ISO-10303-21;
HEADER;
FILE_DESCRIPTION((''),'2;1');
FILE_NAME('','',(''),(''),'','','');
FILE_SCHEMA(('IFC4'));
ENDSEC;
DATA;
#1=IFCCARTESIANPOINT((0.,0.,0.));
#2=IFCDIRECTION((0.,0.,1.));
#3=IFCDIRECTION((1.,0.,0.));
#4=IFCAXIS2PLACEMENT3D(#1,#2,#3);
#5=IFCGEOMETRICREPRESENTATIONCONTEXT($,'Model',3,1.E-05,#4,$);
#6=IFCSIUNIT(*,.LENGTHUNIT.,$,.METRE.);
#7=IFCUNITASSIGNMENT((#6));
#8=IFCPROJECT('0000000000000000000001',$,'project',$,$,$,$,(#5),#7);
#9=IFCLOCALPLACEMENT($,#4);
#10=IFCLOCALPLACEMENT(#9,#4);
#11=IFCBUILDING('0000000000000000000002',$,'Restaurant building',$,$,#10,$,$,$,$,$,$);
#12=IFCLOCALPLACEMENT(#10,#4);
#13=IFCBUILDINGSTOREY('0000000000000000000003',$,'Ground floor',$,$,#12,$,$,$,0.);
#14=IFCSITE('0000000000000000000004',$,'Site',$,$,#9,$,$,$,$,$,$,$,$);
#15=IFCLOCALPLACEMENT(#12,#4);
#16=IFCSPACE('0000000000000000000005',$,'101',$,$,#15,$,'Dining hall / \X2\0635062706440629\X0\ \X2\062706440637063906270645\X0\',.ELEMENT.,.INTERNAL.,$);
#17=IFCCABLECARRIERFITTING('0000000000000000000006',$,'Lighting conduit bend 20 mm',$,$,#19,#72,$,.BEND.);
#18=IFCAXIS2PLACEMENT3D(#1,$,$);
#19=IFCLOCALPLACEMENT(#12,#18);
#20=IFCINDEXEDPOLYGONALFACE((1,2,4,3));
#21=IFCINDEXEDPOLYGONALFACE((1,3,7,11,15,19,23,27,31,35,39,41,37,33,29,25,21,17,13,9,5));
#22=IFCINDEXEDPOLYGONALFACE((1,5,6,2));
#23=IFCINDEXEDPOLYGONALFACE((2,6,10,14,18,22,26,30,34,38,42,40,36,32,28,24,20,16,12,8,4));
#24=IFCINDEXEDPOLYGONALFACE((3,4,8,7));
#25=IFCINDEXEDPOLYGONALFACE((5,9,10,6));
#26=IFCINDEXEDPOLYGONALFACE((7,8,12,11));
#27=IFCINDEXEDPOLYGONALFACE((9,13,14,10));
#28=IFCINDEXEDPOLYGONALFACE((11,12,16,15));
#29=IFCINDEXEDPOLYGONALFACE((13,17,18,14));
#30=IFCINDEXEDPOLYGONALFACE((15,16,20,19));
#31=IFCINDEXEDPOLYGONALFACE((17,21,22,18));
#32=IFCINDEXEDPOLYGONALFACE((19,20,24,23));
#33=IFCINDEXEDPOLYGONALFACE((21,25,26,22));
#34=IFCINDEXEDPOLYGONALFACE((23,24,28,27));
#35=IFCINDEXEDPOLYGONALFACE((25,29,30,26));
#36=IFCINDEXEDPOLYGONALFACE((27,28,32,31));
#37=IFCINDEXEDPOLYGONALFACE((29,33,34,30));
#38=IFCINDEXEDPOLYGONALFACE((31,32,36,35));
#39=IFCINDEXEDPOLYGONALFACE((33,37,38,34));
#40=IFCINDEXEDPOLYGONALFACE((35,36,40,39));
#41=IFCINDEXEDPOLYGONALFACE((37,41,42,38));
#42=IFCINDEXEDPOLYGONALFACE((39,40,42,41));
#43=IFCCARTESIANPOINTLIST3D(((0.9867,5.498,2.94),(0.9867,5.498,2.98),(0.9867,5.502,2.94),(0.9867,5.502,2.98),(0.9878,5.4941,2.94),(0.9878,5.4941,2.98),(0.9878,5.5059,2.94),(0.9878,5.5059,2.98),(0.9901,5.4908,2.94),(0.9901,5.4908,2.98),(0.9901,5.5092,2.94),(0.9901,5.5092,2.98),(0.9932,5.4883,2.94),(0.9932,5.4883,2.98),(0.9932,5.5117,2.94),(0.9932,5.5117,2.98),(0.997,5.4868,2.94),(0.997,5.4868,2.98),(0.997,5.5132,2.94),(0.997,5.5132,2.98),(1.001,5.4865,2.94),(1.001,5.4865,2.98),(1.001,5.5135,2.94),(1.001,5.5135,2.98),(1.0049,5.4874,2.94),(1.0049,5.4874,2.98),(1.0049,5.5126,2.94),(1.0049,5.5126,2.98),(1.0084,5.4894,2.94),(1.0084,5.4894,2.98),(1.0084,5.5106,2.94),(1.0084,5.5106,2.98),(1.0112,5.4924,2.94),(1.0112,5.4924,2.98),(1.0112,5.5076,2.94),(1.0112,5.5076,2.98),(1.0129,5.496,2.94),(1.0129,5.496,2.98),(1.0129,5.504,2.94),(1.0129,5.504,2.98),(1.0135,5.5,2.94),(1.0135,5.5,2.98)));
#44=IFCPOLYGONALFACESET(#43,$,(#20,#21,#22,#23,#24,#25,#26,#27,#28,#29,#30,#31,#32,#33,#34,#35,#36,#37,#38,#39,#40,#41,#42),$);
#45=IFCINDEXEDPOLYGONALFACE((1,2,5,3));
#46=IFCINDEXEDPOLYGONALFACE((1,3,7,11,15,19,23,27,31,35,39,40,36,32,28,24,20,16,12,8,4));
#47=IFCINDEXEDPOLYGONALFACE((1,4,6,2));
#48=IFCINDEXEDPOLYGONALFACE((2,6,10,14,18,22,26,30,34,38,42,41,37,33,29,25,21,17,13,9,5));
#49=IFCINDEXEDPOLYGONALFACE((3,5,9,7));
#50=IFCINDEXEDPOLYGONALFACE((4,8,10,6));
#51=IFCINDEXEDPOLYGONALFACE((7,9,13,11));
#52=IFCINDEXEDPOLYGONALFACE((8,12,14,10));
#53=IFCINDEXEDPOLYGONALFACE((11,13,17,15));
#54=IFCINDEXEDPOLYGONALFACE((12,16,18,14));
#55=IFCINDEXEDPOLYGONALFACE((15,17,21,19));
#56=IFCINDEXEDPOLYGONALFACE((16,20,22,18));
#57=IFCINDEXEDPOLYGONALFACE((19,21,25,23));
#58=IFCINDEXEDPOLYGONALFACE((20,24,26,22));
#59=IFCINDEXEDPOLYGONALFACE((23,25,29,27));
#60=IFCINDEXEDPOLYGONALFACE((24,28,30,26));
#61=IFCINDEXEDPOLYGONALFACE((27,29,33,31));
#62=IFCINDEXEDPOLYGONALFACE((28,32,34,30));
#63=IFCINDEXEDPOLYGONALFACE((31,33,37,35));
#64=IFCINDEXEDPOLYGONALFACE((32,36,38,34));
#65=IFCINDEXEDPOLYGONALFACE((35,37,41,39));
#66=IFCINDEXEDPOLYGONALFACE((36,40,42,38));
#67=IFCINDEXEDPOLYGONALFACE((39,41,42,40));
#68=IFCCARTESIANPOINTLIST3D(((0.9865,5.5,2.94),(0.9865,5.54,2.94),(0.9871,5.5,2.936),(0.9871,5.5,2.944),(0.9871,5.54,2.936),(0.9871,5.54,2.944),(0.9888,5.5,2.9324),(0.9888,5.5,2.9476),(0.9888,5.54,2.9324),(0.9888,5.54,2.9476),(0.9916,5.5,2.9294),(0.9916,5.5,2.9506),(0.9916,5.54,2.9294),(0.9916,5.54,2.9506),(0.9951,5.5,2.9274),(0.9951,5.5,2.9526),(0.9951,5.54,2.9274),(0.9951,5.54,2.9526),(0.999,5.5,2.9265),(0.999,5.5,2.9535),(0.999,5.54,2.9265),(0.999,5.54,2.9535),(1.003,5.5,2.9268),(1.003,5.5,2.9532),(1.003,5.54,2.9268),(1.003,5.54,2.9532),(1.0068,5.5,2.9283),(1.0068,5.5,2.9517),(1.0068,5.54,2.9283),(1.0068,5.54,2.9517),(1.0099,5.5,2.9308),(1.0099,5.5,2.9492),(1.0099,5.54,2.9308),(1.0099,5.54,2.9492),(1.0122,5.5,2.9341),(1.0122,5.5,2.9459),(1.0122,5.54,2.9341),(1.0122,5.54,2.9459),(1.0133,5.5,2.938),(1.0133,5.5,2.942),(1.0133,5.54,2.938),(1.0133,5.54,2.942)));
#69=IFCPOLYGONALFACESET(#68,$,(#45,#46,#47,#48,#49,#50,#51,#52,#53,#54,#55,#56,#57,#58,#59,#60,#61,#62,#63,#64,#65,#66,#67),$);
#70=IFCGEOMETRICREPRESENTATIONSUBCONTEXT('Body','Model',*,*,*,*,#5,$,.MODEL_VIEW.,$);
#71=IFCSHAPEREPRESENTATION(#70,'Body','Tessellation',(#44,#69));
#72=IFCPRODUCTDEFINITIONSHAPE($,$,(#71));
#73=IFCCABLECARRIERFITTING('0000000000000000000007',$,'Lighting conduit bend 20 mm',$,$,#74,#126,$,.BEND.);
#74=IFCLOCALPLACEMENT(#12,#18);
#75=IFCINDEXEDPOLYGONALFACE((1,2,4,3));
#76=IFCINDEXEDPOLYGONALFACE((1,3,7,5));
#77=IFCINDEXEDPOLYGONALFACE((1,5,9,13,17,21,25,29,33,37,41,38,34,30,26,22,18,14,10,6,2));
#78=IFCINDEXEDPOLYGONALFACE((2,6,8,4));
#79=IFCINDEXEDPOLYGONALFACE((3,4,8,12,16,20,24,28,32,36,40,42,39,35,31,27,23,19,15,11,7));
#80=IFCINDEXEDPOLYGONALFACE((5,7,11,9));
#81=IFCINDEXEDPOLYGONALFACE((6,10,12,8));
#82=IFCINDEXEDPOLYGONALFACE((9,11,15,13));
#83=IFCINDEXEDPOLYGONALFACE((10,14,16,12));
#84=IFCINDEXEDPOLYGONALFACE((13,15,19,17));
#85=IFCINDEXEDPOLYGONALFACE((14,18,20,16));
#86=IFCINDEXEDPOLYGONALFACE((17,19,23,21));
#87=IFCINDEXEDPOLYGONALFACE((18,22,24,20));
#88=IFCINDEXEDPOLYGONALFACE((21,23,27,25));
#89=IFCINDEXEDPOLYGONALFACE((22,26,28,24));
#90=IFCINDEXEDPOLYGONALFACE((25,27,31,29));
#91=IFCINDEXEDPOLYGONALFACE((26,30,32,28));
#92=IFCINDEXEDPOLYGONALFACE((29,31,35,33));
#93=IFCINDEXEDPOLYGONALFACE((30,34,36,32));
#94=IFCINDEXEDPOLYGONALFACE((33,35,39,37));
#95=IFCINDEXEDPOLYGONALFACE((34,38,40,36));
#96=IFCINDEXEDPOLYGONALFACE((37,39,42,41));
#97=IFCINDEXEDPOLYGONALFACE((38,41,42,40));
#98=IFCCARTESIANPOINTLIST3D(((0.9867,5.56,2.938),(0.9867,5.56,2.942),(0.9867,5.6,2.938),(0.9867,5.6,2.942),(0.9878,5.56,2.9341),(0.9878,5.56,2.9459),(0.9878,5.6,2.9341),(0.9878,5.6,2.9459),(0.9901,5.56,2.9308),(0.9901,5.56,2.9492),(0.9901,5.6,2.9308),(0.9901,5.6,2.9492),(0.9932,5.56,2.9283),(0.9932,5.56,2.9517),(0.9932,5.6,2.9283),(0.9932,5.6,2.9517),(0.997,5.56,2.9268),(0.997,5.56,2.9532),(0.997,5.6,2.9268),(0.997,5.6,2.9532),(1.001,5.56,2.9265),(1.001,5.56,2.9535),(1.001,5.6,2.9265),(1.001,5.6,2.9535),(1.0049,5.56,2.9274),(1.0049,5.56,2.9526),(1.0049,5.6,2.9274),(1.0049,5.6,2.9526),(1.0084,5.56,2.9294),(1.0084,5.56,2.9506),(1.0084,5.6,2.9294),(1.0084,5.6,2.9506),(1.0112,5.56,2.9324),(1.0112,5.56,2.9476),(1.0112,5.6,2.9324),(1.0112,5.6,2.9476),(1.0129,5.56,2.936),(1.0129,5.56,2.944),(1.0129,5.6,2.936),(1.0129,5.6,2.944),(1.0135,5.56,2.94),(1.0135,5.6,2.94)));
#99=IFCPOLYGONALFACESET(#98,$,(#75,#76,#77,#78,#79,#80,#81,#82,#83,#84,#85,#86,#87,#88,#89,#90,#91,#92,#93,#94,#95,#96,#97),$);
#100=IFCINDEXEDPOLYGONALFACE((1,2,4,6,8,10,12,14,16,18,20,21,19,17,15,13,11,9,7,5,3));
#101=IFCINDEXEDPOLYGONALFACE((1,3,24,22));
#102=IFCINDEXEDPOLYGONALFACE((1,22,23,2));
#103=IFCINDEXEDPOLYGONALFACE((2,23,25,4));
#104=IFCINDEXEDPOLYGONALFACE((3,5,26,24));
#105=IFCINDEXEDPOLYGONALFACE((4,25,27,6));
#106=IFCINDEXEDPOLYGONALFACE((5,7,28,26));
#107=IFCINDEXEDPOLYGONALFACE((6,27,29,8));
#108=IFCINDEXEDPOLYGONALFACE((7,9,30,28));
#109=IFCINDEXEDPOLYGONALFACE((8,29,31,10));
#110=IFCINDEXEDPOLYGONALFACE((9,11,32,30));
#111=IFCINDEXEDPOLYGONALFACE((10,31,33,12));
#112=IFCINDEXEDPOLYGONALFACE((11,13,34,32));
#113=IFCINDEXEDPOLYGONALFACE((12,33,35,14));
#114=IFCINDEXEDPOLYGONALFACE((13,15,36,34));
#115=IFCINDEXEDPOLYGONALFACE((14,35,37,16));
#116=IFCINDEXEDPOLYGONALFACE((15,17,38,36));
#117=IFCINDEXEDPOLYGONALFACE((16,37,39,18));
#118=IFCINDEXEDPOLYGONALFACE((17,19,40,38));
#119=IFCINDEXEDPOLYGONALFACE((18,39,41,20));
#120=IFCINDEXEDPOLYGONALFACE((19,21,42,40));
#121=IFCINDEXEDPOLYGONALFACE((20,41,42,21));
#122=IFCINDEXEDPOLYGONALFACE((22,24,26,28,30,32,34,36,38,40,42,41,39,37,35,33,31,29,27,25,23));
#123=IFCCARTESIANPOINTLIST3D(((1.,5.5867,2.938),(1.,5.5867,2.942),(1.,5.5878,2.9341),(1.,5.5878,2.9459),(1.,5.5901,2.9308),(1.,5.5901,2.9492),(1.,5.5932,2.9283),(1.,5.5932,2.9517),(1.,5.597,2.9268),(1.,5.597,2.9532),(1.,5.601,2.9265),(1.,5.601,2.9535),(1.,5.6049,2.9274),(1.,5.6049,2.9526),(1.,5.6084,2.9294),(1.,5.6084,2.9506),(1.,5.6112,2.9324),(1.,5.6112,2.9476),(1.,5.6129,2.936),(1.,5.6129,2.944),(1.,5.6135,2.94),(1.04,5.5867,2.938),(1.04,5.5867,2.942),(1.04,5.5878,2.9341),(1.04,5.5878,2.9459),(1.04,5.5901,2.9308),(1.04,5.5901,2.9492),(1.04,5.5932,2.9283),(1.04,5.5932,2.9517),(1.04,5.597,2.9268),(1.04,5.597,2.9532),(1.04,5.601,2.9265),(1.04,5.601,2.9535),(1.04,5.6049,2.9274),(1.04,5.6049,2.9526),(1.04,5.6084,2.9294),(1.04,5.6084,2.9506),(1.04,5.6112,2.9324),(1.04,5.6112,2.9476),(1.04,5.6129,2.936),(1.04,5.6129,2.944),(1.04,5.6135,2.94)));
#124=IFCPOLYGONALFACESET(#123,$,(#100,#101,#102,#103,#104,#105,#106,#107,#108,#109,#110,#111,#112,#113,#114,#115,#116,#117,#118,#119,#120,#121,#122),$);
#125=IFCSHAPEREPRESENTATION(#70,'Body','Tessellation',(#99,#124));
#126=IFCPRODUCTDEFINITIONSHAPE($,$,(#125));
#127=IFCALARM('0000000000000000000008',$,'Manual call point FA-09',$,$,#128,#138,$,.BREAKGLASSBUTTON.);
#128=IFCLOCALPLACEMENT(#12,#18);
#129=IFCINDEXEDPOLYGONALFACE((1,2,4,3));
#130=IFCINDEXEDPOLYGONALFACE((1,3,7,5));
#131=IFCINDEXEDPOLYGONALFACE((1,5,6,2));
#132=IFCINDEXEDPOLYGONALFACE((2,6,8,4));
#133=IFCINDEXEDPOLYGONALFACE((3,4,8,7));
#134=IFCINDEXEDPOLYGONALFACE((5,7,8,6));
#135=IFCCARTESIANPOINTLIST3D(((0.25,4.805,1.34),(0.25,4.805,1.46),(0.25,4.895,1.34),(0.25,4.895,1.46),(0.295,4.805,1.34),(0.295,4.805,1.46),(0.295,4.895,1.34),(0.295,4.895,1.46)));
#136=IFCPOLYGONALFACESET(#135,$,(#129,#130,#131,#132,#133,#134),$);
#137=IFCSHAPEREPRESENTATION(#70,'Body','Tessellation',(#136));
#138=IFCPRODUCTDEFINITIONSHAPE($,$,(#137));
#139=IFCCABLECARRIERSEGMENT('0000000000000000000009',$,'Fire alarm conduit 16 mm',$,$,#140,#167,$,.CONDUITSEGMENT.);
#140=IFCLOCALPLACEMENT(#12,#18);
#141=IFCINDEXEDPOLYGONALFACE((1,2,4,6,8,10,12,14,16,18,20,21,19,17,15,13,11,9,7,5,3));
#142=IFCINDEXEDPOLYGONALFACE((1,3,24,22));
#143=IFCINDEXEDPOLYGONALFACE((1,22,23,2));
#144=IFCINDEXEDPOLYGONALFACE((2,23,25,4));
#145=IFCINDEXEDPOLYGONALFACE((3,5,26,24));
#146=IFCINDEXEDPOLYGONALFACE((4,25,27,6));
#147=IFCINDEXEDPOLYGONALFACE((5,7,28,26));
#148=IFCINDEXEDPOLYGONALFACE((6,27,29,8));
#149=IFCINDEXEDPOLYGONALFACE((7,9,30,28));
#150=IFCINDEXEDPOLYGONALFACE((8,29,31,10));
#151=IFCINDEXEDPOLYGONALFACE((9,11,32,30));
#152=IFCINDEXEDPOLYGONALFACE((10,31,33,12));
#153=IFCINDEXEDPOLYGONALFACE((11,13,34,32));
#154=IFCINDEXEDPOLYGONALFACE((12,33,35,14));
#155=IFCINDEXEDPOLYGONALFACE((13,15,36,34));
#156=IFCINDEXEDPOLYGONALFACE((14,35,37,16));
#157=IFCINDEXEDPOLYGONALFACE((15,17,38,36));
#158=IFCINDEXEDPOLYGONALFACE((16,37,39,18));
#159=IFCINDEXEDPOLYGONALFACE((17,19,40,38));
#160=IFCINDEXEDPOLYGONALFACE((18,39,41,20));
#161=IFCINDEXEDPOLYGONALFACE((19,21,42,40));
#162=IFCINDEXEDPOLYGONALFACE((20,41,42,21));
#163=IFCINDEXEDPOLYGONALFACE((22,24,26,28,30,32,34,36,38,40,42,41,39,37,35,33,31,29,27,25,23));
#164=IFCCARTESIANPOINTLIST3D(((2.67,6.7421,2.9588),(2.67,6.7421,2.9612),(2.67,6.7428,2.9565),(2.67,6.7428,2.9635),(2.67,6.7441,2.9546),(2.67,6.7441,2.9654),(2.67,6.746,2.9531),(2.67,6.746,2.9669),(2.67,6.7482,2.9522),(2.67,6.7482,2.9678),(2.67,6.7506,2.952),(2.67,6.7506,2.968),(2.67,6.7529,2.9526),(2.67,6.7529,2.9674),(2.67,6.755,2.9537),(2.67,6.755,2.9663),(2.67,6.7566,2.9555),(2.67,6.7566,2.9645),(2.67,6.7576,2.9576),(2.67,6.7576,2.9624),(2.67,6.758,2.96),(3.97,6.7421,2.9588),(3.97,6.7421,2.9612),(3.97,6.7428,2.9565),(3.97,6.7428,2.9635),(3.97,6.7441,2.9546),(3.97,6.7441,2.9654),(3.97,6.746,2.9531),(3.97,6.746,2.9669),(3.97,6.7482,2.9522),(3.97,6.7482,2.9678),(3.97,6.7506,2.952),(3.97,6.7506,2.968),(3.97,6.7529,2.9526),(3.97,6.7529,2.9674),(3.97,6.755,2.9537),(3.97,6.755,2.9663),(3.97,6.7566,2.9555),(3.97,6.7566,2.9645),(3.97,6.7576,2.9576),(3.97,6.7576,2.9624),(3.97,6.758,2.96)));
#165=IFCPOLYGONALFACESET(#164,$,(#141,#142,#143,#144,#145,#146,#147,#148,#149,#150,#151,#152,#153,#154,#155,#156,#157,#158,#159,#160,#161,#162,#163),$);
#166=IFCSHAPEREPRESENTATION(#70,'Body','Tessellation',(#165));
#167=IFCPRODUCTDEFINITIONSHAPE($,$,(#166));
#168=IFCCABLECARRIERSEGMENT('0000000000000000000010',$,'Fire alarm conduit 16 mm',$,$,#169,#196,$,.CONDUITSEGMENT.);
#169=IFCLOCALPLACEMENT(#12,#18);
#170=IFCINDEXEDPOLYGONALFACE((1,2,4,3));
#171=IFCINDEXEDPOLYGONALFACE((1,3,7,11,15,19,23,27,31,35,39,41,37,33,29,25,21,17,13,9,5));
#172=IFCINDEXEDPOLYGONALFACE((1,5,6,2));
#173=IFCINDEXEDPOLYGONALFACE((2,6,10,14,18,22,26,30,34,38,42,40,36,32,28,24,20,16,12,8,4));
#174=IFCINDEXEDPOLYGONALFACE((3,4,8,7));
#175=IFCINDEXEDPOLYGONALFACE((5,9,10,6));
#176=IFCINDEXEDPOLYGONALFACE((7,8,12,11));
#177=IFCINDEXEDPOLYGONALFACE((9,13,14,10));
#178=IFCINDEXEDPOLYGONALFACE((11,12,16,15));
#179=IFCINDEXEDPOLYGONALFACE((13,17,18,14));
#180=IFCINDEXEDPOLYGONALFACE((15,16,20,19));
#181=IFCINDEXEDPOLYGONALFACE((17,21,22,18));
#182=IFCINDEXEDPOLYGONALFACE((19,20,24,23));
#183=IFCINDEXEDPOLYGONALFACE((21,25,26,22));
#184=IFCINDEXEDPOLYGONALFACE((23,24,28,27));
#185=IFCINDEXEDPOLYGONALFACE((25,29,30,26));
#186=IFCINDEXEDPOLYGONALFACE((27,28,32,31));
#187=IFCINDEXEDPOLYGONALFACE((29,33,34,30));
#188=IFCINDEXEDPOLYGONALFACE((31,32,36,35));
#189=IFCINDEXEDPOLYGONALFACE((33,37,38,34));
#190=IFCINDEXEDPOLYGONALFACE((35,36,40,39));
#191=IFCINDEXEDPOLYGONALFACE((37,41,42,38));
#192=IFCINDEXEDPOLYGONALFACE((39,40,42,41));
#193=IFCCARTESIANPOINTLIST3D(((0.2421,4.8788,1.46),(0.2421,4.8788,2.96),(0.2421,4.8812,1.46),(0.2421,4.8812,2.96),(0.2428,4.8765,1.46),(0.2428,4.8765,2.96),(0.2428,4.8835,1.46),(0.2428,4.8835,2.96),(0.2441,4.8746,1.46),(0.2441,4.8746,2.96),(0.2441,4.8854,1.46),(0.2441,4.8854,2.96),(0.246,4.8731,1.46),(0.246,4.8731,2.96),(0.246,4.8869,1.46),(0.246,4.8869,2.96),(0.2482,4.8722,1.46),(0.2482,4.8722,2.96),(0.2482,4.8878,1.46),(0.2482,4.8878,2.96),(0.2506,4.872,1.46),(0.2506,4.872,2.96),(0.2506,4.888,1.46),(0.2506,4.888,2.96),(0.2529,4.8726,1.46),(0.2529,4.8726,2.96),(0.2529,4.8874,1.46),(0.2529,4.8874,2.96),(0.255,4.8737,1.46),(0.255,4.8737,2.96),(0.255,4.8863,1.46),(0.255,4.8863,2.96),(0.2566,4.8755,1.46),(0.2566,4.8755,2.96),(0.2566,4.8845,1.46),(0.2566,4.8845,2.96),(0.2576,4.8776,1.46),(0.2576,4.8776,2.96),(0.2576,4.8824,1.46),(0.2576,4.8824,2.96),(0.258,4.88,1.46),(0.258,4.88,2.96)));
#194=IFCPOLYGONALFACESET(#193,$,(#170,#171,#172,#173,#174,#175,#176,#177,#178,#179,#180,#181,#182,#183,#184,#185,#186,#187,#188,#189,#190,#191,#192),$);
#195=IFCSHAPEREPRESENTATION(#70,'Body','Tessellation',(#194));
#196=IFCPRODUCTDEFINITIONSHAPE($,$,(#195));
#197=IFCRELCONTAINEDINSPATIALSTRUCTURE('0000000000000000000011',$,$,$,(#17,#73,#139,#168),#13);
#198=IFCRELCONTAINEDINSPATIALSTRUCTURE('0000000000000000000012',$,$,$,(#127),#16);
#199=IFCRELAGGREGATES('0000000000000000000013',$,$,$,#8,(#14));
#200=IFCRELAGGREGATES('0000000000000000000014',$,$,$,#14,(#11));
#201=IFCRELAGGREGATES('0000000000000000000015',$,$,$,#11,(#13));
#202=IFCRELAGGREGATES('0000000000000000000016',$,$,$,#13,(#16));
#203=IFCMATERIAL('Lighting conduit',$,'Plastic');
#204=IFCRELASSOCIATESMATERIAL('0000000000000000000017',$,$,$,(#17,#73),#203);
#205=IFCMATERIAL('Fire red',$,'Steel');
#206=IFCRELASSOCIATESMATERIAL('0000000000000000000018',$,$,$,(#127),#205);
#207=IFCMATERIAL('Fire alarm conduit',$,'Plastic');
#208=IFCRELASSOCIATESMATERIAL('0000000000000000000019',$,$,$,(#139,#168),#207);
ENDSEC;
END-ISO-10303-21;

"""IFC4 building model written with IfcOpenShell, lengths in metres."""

from ifc_helpers import new_model, si_unit, frame, origin, origin_with_axes, origin_2d, place, context, subcontext, project, spatial, rectangle, circle, extrude, material, element, save


model = new_model("IFC4")

# Units and contexts
model_context = context("Model", 3, precision=1e-05, world=origin_with_axes())
body_context = subcontext(model_context, "Body", "Model", "MODEL_VIEW")
ifc_project = project(units=[si_unit("LENGTHUNIT", "METRE")], contexts=[model_context])

# Site, building, storey, space
site_placement = place(None, origin_with_axes())
site = spatial("IfcSite", under=ifc_project, at=site_placement, Name="Site")
building_placement = place(site_placement, origin_with_axes())
building = spatial("IfcBuilding", under=site, at=building_placement, Name="Restaurant building")
storey_placement = place(building_placement, origin_with_axes())
storey = spatial("IfcBuildingStorey", under=building, at=storey_placement, Name="Ground floor", Elevation=0.0)
space_placement = place(storey_placement, origin_with_axes())
space = spatial("IfcSpace", under=storey, at=space_placement, Name="101", LongName="Dining hall / صالة الطعام", CompositionType="ELEMENT", PredefinedType="INTERNAL")

# Shared definitions
ifc_material_1 = material(Name="Lighting conduit", Category="Plastic")

# Cable carrier fittings
cable_carrier_fitting_1_placement = place(storey_placement, frame((1.0, 5.5, 2.94)))
element("IfcCableCarrierFitting", 1, at=cable_carrier_fitting_1_placement, inside=storey, material=ifc_material_1, Name="Lighting conduit bend 20 mm", PredefinedType="BEND", context=body_context, shape_type="SweptSolid", body=[
    extrude(circle(Radius=0.0135, at=origin_2d()), origin(), (0.0, 0.0, 1.0), 0.04),
    extrude(circle(Radius=0.0135, at=origin_2d()), frame((0.0, 0.0, 0.0), z_axis=(0.0, 1.0, 0.0), x_axis=(-1.0, 0.0, 0.0)), (0.0, 0.0, 1.0), 0.04),
])
cable_carrier_fitting_2_placement = place(storey_placement, frame((1.0, 5.6, 2.94)))
element("IfcCableCarrierFitting", 2, at=cable_carrier_fitting_2_placement, inside=storey, material=ifc_material_1, Name="Lighting conduit bend 20 mm", PredefinedType="BEND", context=body_context, shape_type="SweptSolid", body=[
    extrude(circle(Radius=0.0135, at=origin_2d()), frame((0.0, 0.0, 0.0), z_axis=(0.0, -1.0, 0.0), x_axis=(1.0, 0.0, 0.0)), (0.0, 0.0, 1.0), 0.04),
    extrude(circle(Radius=0.0135, at=origin_2d()), frame((0.0, 0.0, 0.0), z_axis=(1.0, 0.0, 0.0), x_axis=(0.0, 1.0, 0.0)), (0.0, 0.0, 1.0), 0.04),
])

# Alarm
ifc_material_2 = material(Name="Fire red", Category="Steel")
alarm_placement = place(storey_placement, frame((0.25, 4.85, 1.4)))
element("IfcAlarm", 3, at=alarm_placement, inside=space, material=ifc_material_2, Name="Manual call point FA-09", PredefinedType="BREAKGLASSBUTTON", context=body_context, shape_type="SweptSolid", body=[
    extrude(rectangle(XDim=0.045, YDim=0.09, at=origin_2d()), frame((0.0225, 0.0, -0.06)), (0.0, 0.0, 1.0), 0.12),
])

# Cable carrier segments
ifc_material_3 = material(Name="Fire alarm conduit", Category="Plastic")
cable_carrier_segment_1_placement = place(storey_placement, frame((2.67, 6.75, 2.96)))
element("IfcCableCarrierSegment", 4, at=cable_carrier_segment_1_placement, inside=storey, material=ifc_material_3, Name="Fire alarm conduit 16 mm", PredefinedType="CONDUITSEGMENT", context=body_context, shape_type="SweptSolid", body=[
    extrude(circle(Radius=0.008, at=origin_2d()), frame((0.0, 0.0, 0.0), z_axis=(1.0, 0.0, 0.0), x_axis=(0.0, 1.0, 0.0)), (0.0, 0.0, 1.0), 1.3),
])
cable_carrier_segment_2_placement = place(storey_placement, frame((0.25, 4.88, 2.96)))
element("IfcCableCarrierSegment", 5, at=cable_carrier_segment_2_placement, inside=storey, material=ifc_material_3, Name="Fire alarm conduit 16 mm", PredefinedType="CONDUITSEGMENT", context=body_context, shape_type="SweptSolid", body=[
    extrude(circle(Radius=0.008, at=origin_2d()), frame((0.0, 0.0, 0.0), z_axis=(0.0, 0.0, -1.0), x_axis=(1.0, 0.0, 0.0)), (0.0, 0.0, 1.0), 1.5),
])

save(model, "model.ifc")
